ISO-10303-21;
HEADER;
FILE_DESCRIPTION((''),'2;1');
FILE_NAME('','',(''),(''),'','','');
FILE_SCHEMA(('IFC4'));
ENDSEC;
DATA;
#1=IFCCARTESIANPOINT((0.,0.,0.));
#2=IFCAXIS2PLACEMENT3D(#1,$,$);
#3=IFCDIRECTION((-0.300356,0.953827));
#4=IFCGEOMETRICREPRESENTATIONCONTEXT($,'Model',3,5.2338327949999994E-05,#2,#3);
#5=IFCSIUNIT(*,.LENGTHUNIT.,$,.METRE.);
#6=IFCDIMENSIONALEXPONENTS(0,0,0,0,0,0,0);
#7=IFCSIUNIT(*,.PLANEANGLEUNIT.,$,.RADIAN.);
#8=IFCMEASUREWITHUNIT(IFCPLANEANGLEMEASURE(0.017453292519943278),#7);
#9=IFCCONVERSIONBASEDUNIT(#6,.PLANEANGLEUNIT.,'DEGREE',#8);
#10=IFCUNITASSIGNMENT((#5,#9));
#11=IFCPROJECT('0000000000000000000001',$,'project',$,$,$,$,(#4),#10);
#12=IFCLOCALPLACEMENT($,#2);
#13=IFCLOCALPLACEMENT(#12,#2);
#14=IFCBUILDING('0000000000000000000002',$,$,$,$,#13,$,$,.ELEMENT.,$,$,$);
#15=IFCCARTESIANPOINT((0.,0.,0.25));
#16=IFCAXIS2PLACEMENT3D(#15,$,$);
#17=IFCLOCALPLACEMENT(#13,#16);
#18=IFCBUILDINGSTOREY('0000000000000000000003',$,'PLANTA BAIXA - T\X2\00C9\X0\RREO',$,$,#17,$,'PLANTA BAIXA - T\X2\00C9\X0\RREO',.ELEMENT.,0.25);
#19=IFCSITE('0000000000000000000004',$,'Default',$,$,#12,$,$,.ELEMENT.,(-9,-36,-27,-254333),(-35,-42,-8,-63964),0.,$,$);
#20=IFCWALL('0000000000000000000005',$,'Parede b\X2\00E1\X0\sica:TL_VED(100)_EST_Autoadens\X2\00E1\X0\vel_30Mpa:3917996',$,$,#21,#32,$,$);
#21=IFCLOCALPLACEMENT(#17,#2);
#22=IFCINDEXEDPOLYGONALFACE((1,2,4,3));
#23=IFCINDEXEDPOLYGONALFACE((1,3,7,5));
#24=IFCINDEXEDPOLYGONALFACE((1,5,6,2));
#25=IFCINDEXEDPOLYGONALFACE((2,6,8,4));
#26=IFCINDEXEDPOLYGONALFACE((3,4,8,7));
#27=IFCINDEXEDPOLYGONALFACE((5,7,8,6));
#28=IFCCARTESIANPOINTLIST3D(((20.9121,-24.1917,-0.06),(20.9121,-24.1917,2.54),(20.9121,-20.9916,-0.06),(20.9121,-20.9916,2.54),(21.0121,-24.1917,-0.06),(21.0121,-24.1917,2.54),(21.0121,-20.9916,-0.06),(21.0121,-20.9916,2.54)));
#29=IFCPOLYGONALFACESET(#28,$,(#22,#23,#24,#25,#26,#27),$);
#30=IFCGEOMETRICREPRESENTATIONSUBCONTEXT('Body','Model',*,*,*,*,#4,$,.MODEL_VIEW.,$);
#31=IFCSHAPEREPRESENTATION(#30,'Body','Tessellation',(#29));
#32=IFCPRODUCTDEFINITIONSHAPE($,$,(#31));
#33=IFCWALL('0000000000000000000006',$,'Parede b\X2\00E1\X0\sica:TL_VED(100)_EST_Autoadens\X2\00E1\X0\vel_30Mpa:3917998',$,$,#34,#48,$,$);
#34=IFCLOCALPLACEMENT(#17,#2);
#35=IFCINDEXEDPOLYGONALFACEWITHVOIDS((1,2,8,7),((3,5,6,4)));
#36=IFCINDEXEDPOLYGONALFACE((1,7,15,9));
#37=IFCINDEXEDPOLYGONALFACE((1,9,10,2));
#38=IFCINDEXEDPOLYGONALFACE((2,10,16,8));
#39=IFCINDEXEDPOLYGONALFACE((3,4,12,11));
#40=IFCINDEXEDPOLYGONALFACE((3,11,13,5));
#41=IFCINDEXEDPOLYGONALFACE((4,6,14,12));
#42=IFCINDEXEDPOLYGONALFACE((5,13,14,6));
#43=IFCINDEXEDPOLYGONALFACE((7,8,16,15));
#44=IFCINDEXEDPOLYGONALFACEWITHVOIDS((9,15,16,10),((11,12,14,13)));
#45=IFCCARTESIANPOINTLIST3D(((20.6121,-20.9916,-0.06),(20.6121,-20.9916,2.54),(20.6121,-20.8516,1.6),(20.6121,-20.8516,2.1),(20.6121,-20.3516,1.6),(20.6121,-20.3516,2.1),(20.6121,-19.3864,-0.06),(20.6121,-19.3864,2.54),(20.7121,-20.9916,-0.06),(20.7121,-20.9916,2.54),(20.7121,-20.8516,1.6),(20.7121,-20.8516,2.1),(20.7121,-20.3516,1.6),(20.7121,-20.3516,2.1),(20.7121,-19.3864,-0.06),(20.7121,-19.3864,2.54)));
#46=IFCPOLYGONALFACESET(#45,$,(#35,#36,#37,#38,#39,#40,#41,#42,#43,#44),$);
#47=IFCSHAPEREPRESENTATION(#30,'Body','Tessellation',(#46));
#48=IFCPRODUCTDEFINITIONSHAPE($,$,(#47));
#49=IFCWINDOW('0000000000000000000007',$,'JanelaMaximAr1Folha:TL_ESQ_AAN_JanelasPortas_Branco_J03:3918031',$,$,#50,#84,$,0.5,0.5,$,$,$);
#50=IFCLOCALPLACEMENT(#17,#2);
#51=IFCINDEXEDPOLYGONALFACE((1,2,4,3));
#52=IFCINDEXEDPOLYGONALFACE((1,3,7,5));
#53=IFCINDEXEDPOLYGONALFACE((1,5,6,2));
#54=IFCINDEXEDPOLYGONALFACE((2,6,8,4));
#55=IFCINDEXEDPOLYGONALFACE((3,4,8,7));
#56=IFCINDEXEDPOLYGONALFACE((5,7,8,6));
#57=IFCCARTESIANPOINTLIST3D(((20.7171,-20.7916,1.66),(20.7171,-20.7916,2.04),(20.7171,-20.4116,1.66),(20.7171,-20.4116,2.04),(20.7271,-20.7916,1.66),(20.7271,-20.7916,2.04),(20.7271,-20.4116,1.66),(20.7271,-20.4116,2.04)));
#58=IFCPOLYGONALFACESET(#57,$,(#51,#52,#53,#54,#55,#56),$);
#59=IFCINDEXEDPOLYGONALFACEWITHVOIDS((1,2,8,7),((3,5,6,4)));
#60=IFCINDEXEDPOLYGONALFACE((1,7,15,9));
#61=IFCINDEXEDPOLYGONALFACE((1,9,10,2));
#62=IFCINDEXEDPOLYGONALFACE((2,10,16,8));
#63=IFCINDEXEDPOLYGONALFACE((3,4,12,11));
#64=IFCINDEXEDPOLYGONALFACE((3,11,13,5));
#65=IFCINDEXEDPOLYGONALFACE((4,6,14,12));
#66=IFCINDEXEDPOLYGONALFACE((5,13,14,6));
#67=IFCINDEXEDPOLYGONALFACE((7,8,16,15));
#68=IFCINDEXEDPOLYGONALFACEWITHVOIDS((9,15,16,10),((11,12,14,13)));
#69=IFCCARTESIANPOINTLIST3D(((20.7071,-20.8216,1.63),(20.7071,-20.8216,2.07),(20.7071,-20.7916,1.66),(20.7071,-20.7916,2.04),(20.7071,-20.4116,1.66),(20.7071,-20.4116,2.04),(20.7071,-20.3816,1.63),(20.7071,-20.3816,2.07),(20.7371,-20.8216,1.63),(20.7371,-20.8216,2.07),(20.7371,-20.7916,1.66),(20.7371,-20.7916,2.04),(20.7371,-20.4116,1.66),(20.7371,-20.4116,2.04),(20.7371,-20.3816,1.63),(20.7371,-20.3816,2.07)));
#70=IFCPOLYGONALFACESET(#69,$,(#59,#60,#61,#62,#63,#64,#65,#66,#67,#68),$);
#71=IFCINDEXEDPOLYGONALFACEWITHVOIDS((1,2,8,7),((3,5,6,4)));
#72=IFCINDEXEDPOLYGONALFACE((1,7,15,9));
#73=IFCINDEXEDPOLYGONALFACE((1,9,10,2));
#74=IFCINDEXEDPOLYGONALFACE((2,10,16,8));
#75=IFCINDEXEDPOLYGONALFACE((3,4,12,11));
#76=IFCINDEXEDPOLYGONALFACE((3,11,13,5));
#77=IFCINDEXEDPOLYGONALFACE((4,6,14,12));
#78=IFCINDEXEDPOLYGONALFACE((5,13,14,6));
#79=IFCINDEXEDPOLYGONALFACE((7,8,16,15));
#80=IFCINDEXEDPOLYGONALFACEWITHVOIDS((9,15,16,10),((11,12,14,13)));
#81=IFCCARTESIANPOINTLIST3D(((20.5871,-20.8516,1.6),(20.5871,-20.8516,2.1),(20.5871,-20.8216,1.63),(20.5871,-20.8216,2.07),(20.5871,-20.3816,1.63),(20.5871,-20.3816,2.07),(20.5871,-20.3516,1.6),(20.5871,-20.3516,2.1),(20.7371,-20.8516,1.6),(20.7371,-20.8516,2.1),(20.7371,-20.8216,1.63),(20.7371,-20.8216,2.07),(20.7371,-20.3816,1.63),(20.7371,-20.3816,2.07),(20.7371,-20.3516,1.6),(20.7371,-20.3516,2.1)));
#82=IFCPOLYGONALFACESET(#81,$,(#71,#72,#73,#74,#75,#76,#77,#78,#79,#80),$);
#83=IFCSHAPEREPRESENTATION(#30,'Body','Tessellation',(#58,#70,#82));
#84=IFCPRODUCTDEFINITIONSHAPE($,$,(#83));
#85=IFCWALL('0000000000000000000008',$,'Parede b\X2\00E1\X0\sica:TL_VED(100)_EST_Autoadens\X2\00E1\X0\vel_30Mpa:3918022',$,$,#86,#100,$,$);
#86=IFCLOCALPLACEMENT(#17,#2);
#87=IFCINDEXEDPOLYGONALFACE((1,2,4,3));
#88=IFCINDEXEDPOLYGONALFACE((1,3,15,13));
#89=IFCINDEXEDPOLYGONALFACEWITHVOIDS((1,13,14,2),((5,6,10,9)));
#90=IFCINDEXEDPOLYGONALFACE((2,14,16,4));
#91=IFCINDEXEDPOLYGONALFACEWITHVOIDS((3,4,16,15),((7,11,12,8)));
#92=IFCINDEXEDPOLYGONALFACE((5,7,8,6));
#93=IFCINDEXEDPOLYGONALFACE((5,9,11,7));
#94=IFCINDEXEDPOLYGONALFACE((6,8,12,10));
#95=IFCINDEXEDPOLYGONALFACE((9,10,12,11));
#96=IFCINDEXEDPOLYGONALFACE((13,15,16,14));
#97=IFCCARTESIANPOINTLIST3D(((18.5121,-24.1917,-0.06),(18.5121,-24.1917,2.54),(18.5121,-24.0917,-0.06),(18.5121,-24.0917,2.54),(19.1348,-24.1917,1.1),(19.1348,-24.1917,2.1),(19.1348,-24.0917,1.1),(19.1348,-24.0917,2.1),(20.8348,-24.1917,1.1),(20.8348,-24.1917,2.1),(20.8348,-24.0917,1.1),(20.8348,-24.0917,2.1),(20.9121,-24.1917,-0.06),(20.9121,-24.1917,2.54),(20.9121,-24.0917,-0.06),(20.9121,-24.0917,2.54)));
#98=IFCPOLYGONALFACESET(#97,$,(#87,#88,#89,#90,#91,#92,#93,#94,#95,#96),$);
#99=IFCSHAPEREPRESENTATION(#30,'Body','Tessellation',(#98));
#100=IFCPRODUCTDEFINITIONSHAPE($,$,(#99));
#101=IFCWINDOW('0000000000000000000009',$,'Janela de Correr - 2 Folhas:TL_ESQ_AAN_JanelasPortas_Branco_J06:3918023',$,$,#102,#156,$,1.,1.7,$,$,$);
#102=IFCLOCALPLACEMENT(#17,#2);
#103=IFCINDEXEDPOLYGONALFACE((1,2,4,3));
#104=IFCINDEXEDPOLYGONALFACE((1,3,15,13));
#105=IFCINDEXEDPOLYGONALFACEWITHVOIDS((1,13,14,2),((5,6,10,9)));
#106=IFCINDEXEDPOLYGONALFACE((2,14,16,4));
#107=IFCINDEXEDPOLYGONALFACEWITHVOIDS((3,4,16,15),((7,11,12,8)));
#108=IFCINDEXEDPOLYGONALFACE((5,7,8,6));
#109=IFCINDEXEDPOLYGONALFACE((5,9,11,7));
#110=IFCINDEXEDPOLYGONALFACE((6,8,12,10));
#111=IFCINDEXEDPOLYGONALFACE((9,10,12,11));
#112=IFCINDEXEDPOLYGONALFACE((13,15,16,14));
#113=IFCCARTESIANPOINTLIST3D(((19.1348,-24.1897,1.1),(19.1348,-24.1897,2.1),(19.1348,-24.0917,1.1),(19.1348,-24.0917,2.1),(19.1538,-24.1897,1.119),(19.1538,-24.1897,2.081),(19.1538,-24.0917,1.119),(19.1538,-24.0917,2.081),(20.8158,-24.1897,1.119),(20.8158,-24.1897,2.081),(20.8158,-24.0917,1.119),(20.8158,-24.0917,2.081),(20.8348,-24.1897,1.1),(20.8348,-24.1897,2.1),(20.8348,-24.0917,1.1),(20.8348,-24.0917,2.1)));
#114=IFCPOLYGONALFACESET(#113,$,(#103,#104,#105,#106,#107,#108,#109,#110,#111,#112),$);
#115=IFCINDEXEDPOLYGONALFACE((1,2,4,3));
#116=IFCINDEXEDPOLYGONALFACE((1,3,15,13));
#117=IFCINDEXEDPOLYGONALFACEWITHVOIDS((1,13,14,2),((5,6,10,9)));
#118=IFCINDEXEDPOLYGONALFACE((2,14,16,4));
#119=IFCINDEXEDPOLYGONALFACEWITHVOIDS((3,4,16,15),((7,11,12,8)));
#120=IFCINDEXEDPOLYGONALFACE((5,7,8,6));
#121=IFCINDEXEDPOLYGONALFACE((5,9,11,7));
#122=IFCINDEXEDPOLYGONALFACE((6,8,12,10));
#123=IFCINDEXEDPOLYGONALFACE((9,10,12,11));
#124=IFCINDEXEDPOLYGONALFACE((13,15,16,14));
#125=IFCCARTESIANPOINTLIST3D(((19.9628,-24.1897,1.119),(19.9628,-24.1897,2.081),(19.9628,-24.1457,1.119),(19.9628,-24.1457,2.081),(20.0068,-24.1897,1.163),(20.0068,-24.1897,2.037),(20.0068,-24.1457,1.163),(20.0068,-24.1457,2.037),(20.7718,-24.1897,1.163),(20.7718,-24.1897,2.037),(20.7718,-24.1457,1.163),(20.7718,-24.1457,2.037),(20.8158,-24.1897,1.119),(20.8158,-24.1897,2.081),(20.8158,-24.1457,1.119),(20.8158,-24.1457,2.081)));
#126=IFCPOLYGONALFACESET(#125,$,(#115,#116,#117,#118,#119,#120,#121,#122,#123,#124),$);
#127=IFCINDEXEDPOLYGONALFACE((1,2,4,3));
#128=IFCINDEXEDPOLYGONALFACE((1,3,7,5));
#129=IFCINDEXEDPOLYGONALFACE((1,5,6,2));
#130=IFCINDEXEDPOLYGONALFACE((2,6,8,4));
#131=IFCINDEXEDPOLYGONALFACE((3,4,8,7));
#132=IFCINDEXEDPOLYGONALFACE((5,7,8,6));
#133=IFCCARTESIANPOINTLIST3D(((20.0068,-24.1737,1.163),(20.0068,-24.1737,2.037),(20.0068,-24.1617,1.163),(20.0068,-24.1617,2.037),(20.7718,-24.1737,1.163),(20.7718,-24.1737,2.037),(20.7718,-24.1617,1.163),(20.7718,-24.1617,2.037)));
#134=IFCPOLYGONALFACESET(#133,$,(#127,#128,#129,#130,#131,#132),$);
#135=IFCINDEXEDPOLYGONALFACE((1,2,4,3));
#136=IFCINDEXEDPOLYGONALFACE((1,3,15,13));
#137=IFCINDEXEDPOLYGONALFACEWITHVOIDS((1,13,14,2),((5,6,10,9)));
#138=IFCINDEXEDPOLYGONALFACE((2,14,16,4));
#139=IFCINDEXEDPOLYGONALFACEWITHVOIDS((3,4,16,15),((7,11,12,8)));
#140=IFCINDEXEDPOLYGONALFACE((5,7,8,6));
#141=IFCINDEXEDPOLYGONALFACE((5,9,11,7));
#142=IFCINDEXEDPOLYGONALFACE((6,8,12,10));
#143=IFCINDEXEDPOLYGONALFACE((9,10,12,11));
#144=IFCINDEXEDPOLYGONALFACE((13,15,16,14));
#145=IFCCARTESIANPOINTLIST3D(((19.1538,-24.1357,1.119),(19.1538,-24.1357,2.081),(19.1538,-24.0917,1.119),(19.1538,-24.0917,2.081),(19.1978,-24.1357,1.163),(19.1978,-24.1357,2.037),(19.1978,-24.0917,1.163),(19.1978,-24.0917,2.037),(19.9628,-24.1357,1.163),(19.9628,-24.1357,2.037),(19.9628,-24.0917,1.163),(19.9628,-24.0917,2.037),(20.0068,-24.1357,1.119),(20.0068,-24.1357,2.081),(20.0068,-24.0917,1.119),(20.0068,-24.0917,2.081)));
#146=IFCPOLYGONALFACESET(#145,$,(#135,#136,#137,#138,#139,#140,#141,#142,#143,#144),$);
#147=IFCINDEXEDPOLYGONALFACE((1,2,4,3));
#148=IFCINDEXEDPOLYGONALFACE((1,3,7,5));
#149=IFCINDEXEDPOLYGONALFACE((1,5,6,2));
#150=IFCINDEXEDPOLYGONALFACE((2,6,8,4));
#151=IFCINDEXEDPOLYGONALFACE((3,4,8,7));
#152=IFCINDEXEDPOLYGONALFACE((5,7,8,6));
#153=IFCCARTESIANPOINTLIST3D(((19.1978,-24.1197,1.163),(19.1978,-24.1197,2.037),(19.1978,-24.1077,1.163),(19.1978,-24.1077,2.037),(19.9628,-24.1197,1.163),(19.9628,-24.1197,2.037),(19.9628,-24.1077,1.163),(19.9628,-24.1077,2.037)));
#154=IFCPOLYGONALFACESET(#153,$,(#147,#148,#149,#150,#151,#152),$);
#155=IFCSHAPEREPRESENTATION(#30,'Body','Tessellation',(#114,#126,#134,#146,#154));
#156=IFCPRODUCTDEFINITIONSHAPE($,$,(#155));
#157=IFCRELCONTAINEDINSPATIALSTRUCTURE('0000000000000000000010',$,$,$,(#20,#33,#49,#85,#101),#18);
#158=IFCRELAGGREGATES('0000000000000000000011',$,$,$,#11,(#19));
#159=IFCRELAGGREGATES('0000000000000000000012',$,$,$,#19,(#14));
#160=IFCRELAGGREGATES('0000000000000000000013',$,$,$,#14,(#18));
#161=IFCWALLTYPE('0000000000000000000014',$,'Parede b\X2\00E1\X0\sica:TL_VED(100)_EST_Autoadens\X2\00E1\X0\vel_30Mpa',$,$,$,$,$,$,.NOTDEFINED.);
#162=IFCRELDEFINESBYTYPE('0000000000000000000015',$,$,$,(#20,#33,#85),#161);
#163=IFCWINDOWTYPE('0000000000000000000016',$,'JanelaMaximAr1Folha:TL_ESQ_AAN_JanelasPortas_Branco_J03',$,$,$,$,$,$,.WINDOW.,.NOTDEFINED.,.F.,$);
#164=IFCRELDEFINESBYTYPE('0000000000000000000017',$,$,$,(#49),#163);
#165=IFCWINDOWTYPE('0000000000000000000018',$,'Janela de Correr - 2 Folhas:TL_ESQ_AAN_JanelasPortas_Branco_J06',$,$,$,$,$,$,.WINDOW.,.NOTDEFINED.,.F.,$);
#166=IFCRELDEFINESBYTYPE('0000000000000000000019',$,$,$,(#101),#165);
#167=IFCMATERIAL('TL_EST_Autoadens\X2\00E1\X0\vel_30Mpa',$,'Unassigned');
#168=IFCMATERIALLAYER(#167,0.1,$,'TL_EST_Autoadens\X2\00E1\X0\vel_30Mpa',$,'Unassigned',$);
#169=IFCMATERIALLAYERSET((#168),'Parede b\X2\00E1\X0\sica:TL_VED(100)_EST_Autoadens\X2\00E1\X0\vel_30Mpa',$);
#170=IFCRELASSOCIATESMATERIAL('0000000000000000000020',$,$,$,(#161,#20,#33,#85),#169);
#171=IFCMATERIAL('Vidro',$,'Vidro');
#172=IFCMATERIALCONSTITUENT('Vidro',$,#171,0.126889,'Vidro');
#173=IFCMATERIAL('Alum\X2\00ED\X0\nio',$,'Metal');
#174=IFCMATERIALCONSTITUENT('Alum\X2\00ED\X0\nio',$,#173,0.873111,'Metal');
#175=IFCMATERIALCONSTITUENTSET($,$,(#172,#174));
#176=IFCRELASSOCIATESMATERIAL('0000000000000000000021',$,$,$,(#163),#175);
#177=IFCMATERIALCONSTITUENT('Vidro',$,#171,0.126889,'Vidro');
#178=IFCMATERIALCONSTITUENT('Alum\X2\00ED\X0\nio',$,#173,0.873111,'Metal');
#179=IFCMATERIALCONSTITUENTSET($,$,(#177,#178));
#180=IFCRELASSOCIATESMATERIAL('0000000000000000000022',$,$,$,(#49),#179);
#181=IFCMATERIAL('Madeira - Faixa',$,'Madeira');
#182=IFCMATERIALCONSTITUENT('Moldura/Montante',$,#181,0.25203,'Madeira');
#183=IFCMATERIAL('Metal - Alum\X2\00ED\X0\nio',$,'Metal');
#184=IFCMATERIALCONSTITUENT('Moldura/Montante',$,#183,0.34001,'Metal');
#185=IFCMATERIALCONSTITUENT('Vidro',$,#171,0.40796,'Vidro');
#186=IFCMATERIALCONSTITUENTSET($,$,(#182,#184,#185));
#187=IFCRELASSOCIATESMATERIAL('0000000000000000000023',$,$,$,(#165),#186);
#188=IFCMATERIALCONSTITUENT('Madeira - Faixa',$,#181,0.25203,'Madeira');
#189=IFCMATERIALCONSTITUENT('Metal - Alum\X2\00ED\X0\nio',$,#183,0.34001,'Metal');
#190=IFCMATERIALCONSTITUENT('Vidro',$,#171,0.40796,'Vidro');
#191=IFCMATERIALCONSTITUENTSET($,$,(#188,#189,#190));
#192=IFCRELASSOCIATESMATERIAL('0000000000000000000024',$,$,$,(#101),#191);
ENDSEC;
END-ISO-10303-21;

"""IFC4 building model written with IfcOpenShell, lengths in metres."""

from ifc_helpers import new_model, entity, si_unit, converted_unit, direction, frame, frame_2d, origin, origin_2d_with_axis, place, context, subcontext, project, spatial, polyline, rectangle, outline, extrude, source, transform, mapped, material, layer, layer_set, layer_usage, constituent, constituent_set, type_object, type_shapes, element, fill, save


model = new_model("IFC4")

# Units and contexts
model_context = context("Model", 3, precision=5.2338327949999994e-05, world=origin(), true_north=direction((-0.300356, 0.953827)))
body_context = subcontext(model_context, "Body", "Model", "MODEL_VIEW")
ifc_project = project(units=[si_unit("LENGTHUNIT", "METRE"), converted_unit("PLANEANGLEUNIT", "DEGREE", entity("IfcPlaneAngleMeasure", 0.017453292519943278), si_unit("PLANEANGLEUNIT", "RADIAN"), dimensions=[0, 0, 0, 0, 0, 0, 0])], contexts=[model_context])

# Site, building, storey
site_placement = place(None, origin())
site = spatial("IfcSite", under=ifc_project, at=site_placement, Name="Default", CompositionType="ELEMENT", RefLatitude=(-9, -36, -27, -254333), RefLongitude=(-35, -42, -8, -63964), RefElevation=0.0)
building_placement = place(site_placement, origin())
building = spatial("IfcBuilding", under=site, at=building_placement, CompositionType="ELEMENT")
storey_placement = place(building_placement, frame((0.0, 0.0, 0.25)))
storey = spatial("IfcBuildingStorey", under=building, at=storey_placement, Name="PLANTA BAIXA - TÉRREO", LongName="PLANTA BAIXA - TÉRREO", CompositionType="ELEMENT", Elevation=0.25)

# Wall
ifc_material_1 = material(Name="TL_EST_Autoadensável_30Mpa", Category="Unassigned")
ifc_layer_1 = layer(ifc_material_1, 0.1, Name="TL_EST_Autoadensável_30Mpa", Category="Unassigned")
ifc_layer_set_1 = layer_set([ifc_layer_1], Name="Parede básica:TL_VED(100)_EST_Autoadensável_30Mpa")
ifc_layer_usage_1 = layer_usage(ifc_layer_set_1, "AXIS2", "NEGATIVE", 0.05)
wall_type_1 = type_object("IfcWallType", Name="Parede básica:TL_VED(100)_EST_Autoadensável_30Mpa", PredefinedType="NOTDEFINED", material=ifc_layer_set_1)
wall_1_placement = place(storey_placement, frame((20.9621, -24.1917, -0.06), z_axis=(0.0, 0.0, 1.0), x_axis=(0.0, 1.0, 0.0)))
element("IfcWall", 1, at=wall_1_placement, inside=storey, type_object=wall_type_1, material=ifc_layer_usage_1, Name="Parede básica:TL_VED(100)_EST_Autoadensável_30Mpa:3917996", context=body_context, shape_type="SweptSolid", body=[
    extrude(rectangle(XDim=3.2001, YDim=0.1, at=frame_2d((1.6001, 0.0), x_axis=(-1.0, 0.0))), origin(), (0.0, 0.0, 1.0), 2.6),
])

# Walls, openings, windows
ifc_layer_usage_2 = layer_usage(ifc_layer_set_1, "AXIS2", "NEGATIVE", 0.05)
wall_2_placement = place(storey_placement, frame((20.6621, -19.3864, -0.06), z_axis=(0.0, 0.0, 1.0), x_axis=(0.0, -1.0, 0.0)))
wall_2 = element("IfcWall", 2, at=wall_2_placement, inside=storey, type_object=wall_type_1, material=ifc_layer_usage_2, Name="Parede básica:TL_VED(100)_EST_Autoadensável_30Mpa:3917998", context=body_context, shape_type="SweptSolid", body=[
    extrude(rectangle(XDim=1.6052, YDim=0.1, at=frame_2d((0.8026, 0.0), x_axis=(-1.0, 0.0))), origin(), (0.0, 0.0, 1.0), 2.6),
])
opening_1_placement = place(wall_2_placement, frame((1.4652, 0.05, 1.66)))
opening_1 = element("IfcOpeningElement", 3, at=opening_1_placement, cuts=wall_2, PredefinedType="OPENING", context=body_context, shape_type="SweptSolid", body=[
    extrude(rectangle(XDim=0.5, YDim=0.5, at=frame_2d((0.25, 0.25), x_axis=(1.0, 0.0))), frame((0.0, 0.0, 0.0), z_axis=(0.0, -1.0, 0.0), x_axis=(0.0, 0.0, 1.0)), (0.0, 0.0, 1.0), 0.1),
])
ifc_material_2 = material(Name="Vidro", Category="Vidro")
ifc_constituent_1 = constituent(ifc_material_2, Name="Vidro", Category="Vidro", fraction=0.126889)
ifc_material_3 = material(Name="Alumínio", Category="Metal")
ifc_constituent_2 = constituent(ifc_material_3, Name="Alumínio", Category="Metal", fraction=0.873111)
ifc_constituent_set_1 = constituent_set(constituents=[ifc_constituent_1, ifc_constituent_2])
ifc_constituent_3 = constituent(ifc_material_2, Name="Vidro", Category="Vidro", fraction=0.126889)
ifc_constituent_4 = constituent(ifc_material_3, Name="Alumínio", Category="Metal", fraction=0.873111)
ifc_constituent_set_2 = constituent_set(constituents=[ifc_constituent_3, ifc_constituent_4])
window_type_1 = type_object("IfcWindowType", Name="JanelaMaximAr1Folha:TL_ESQ_AAN_JanelasPortas_Branco_J03", ParameterTakesPrecedence=False, PartitioningType="NOTDEFINED", PredefinedType="WINDOW", material=ifc_constituent_set_2)
shared_shape_1 = source(origin(), body_context, "Body", "SweptSolid", [
    extrude(rectangle(XDim=0.01, YDim=0.38, at=frame_2d((0.0, 0.0), x_axis=(1.0, 0.0))), frame((0.25, -0.01, 0.06), z_axis=(0.0, 0.0, 1.0), x_axis=(0.0, 1.0, 0.0)), (0.0, 0.0, 1.0), 0.38),
    extrude(outline(polyline([(-0.22, -0.22), (0.22, -0.22), (0.22, 0.22), (-0.22, 0.22), (-0.22, -0.22)]), holes=[polyline([(0.19, 0.19), (0.19, -0.19), (-0.19, -0.19), (-0.19, 0.19), (0.19, 0.19)])]), frame((0.25, -0.025, 0.25), z_axis=(0.0, 1.0, 0.0), x_axis=(0.0, 0.0, -1.0)), (0.0, 0.0, 1.0), 0.03),
    extrude(outline(polyline([(-0.25, -0.25), (0.25, -0.25), (0.25, 0.25), (-0.25, 0.25), (-0.25, -0.25)]), holes=[polyline([(-0.22, -0.22), (-0.22, 0.22), (0.22, 0.22), (0.22, -0.22), (-0.22, -0.22)])]), frame((0.25, -0.025, 0.25), z_axis=(0.0, 1.0, 0.0), x_axis=(0.0, 0.0, -1.0)), (0.0, 0.0, 1.0), 0.15),
])
type_shapes(window_type_1, [shared_shape_1])
window_1_placement = place(opening_1_placement, frame((0.0, 0.0, 0.0), z_axis=(0.0, 0.0, 1.0), x_axis=(-1.0, 0.0, 0.0)))
window_1 = element("IfcWindow", 4, at=window_1_placement, inside=storey, type_object=window_type_1, material=ifc_constituent_set_1, Name="JanelaMaximAr1Folha:TL_ESQ_AAN_JanelasPortas_Branco_J03:3918031", OverallHeight=0.5, OverallWidth=0.5, context=body_context, shape_type="MappedRepresentation", body=[
    mapped(shared_shape_1, transform((0.0, 0.0, 0.0), scale=1.0)),
])
fill(opening_1, window_1)
ifc_layer_usage_3 = layer_usage(ifc_layer_set_1, "AXIS2", "NEGATIVE", 0.05)
wall_3_placement = place(storey_placement, frame((20.9121, -24.1417, -0.06), z_axis=(0.0, 0.0, 1.0), x_axis=(-1.0, 0.0, 0.0)))
wall_3 = element("IfcWall", 5, at=wall_3_placement, inside=storey, type_object=wall_type_1, material=ifc_layer_usage_3, Name="Parede básica:TL_VED(100)_EST_Autoadensável_30Mpa:3918022", context=body_context, shape_type="SweptSolid", body=[
    extrude(rectangle(XDim=2.4, YDim=0.1, at=frame_2d((1.2, 0.0), x_axis=(-1.0, 0.0))), origin(), (0.0, 0.0, 1.0), 2.6),
])
opening_2_placement = place(wall_3_placement, frame((0.0774, -0.05, 1.16)))
opening_2 = element("IfcOpeningElement", 6, at=opening_2_placement, cuts=wall_3, PredefinedType="OPENING", context=body_context, shape_type="SweptSolid", body=[
    extrude(rectangle(XDim=1.0, YDim=1.7, at=frame_2d((0.5, 0.85), x_axis=(-1.0, 0.0))), frame((0.0, 0.0, 0.0), z_axis=(0.0, 1.0, 0.0), x_axis=(0.0, 0.0, 1.0)), (0.0, 0.0, 1.0), 0.1),
])
ifc_material_4 = material(Name="Madeira - Faixa", Category="Madeira")
ifc_constituent_5 = constituent(ifc_material_4, Name="Madeira - Faixa", Category="Madeira", fraction=0.25203)
ifc_material_5 = material(Name="Metal - Alumínio", Category="Metal")
ifc_constituent_6 = constituent(ifc_material_5, Name="Metal - Alumínio", Category="Metal", fraction=0.34001)
ifc_constituent_7 = constituent(ifc_material_2, Name="Vidro", Category="Vidro", fraction=0.40796)
ifc_constituent_set_3 = constituent_set(constituents=[ifc_constituent_5, ifc_constituent_6, ifc_constituent_7])
ifc_constituent_8 = constituent(ifc_material_4, Name="Moldura/Montante", Category="Madeira", fraction=0.25203)
ifc_constituent_9 = constituent(ifc_material_5, Name="Moldura/Montante", Category="Metal", fraction=0.34001)
ifc_constituent_10 = constituent(ifc_material_2, Name="Vidro", Category="Vidro", fraction=0.40796)
ifc_constituent_set_4 = constituent_set(constituents=[ifc_constituent_8, ifc_constituent_9, ifc_constituent_10])
window_type_2 = type_object("IfcWindowType", Name="Janela de Correr - 2 Folhas:TL_ESQ_AAN_JanelasPortas_Branco_J06", ParameterTakesPrecedence=False, PartitioningType="NOTDEFINED", PredefinedType="WINDOW", material=ifc_constituent_set_4)
shared_shape_2 = source(origin(), body_context, "Body", "SweptSolid", [
    extrude(outline(polyline([(-0.85, -0.5), (0.85, -0.5), (0.85, 0.5), (-0.85, 0.5), (-0.85, -0.5)]), holes=[polyline([(-0.831, -0.481), (-0.831, 0.481), (0.831, 0.481), (0.831, -0.481), (-0.831, -0.481)])]), frame((0.85, 0.124, 0.5), z_axis=(0.0, -1.0, 0.0), x_axis=(-1.0, 0.0, 0.0)), (0.0, 0.0, 1.0), 0.098),
    extrude(outline(polyline([(-0.4265, -0.481), (0.4265, -0.481), (0.4265, 0.481), (-0.4265, 0.481), (-0.4265, -0.481)]), holes=[polyline([(-0.3825, -0.437), (-0.3825, 0.437), (0.3825, 0.437), (0.3825, -0.437), (-0.3825, -0.437)])]), frame((0.4455, 0.124, 0.5), z_axis=(0.0, -1.0, 0.0), x_axis=(-1.0, 0.0, 0.0)), (0.0, 0.0, 1.0), 0.044),
    extrude(rectangle(XDim=0.765, YDim=0.012, at=origin_2d_with_axis()), frame((0.4455, 0.102, 0.063), z_axis=(0.0, 0.0, 1.0), x_axis=(-1.0, 0.0, 0.0)), (0.0, 0.0, 1.0), 0.874),
    extrude(outline(polyline([(-0.481, -0.4265), (0.481, -0.4265), (0.481, 0.4265), (-0.481, 0.4265), (-0.481, -0.4265)]), holes=[polyline([(-0.437, -0.3825), (-0.437, 0.3825), (0.437, 0.3825), (0.437, -0.3825), (-0.437, -0.3825)])]), frame((1.2545, 0.07, 0.5), z_axis=(0.0, -1.0, 0.0), x_axis=(0.0, 0.0, -1.0)), (0.0, 0.0, 1.0), 0.044),
    extrude(rectangle(XDim=0.765, YDim=0.012, at=origin_2d_with_axis()), frame((1.2545, 0.048, 0.063), z_axis=(0.0, 0.0, 1.0), x_axis=(-1.0, 0.0, 0.0)), (0.0, 0.0, 1.0), 0.874),
])
type_shapes(window_type_2, [shared_shape_2])
window_2_placement = place(opening_2_placement, frame((0.0, -0.026, 0.0)))
window_2 = element("IfcWindow", 7, at=window_2_placement, inside=storey, type_object=window_type_2, material=ifc_constituent_set_3, Name="Janela de Correr - 2 Folhas:TL_ESQ_AAN_JanelasPortas_Branco_J06:3918023", OverallHeight=1.0, OverallWidth=1.7, context=body_context, shape_type="MappedRepresentation", body=[
    mapped(shared_shape_2, transform((0.0, 0.0, 0.0), scale=1.0)),
])
fill(opening_2, window_2)

save(model, "model.ifc")
